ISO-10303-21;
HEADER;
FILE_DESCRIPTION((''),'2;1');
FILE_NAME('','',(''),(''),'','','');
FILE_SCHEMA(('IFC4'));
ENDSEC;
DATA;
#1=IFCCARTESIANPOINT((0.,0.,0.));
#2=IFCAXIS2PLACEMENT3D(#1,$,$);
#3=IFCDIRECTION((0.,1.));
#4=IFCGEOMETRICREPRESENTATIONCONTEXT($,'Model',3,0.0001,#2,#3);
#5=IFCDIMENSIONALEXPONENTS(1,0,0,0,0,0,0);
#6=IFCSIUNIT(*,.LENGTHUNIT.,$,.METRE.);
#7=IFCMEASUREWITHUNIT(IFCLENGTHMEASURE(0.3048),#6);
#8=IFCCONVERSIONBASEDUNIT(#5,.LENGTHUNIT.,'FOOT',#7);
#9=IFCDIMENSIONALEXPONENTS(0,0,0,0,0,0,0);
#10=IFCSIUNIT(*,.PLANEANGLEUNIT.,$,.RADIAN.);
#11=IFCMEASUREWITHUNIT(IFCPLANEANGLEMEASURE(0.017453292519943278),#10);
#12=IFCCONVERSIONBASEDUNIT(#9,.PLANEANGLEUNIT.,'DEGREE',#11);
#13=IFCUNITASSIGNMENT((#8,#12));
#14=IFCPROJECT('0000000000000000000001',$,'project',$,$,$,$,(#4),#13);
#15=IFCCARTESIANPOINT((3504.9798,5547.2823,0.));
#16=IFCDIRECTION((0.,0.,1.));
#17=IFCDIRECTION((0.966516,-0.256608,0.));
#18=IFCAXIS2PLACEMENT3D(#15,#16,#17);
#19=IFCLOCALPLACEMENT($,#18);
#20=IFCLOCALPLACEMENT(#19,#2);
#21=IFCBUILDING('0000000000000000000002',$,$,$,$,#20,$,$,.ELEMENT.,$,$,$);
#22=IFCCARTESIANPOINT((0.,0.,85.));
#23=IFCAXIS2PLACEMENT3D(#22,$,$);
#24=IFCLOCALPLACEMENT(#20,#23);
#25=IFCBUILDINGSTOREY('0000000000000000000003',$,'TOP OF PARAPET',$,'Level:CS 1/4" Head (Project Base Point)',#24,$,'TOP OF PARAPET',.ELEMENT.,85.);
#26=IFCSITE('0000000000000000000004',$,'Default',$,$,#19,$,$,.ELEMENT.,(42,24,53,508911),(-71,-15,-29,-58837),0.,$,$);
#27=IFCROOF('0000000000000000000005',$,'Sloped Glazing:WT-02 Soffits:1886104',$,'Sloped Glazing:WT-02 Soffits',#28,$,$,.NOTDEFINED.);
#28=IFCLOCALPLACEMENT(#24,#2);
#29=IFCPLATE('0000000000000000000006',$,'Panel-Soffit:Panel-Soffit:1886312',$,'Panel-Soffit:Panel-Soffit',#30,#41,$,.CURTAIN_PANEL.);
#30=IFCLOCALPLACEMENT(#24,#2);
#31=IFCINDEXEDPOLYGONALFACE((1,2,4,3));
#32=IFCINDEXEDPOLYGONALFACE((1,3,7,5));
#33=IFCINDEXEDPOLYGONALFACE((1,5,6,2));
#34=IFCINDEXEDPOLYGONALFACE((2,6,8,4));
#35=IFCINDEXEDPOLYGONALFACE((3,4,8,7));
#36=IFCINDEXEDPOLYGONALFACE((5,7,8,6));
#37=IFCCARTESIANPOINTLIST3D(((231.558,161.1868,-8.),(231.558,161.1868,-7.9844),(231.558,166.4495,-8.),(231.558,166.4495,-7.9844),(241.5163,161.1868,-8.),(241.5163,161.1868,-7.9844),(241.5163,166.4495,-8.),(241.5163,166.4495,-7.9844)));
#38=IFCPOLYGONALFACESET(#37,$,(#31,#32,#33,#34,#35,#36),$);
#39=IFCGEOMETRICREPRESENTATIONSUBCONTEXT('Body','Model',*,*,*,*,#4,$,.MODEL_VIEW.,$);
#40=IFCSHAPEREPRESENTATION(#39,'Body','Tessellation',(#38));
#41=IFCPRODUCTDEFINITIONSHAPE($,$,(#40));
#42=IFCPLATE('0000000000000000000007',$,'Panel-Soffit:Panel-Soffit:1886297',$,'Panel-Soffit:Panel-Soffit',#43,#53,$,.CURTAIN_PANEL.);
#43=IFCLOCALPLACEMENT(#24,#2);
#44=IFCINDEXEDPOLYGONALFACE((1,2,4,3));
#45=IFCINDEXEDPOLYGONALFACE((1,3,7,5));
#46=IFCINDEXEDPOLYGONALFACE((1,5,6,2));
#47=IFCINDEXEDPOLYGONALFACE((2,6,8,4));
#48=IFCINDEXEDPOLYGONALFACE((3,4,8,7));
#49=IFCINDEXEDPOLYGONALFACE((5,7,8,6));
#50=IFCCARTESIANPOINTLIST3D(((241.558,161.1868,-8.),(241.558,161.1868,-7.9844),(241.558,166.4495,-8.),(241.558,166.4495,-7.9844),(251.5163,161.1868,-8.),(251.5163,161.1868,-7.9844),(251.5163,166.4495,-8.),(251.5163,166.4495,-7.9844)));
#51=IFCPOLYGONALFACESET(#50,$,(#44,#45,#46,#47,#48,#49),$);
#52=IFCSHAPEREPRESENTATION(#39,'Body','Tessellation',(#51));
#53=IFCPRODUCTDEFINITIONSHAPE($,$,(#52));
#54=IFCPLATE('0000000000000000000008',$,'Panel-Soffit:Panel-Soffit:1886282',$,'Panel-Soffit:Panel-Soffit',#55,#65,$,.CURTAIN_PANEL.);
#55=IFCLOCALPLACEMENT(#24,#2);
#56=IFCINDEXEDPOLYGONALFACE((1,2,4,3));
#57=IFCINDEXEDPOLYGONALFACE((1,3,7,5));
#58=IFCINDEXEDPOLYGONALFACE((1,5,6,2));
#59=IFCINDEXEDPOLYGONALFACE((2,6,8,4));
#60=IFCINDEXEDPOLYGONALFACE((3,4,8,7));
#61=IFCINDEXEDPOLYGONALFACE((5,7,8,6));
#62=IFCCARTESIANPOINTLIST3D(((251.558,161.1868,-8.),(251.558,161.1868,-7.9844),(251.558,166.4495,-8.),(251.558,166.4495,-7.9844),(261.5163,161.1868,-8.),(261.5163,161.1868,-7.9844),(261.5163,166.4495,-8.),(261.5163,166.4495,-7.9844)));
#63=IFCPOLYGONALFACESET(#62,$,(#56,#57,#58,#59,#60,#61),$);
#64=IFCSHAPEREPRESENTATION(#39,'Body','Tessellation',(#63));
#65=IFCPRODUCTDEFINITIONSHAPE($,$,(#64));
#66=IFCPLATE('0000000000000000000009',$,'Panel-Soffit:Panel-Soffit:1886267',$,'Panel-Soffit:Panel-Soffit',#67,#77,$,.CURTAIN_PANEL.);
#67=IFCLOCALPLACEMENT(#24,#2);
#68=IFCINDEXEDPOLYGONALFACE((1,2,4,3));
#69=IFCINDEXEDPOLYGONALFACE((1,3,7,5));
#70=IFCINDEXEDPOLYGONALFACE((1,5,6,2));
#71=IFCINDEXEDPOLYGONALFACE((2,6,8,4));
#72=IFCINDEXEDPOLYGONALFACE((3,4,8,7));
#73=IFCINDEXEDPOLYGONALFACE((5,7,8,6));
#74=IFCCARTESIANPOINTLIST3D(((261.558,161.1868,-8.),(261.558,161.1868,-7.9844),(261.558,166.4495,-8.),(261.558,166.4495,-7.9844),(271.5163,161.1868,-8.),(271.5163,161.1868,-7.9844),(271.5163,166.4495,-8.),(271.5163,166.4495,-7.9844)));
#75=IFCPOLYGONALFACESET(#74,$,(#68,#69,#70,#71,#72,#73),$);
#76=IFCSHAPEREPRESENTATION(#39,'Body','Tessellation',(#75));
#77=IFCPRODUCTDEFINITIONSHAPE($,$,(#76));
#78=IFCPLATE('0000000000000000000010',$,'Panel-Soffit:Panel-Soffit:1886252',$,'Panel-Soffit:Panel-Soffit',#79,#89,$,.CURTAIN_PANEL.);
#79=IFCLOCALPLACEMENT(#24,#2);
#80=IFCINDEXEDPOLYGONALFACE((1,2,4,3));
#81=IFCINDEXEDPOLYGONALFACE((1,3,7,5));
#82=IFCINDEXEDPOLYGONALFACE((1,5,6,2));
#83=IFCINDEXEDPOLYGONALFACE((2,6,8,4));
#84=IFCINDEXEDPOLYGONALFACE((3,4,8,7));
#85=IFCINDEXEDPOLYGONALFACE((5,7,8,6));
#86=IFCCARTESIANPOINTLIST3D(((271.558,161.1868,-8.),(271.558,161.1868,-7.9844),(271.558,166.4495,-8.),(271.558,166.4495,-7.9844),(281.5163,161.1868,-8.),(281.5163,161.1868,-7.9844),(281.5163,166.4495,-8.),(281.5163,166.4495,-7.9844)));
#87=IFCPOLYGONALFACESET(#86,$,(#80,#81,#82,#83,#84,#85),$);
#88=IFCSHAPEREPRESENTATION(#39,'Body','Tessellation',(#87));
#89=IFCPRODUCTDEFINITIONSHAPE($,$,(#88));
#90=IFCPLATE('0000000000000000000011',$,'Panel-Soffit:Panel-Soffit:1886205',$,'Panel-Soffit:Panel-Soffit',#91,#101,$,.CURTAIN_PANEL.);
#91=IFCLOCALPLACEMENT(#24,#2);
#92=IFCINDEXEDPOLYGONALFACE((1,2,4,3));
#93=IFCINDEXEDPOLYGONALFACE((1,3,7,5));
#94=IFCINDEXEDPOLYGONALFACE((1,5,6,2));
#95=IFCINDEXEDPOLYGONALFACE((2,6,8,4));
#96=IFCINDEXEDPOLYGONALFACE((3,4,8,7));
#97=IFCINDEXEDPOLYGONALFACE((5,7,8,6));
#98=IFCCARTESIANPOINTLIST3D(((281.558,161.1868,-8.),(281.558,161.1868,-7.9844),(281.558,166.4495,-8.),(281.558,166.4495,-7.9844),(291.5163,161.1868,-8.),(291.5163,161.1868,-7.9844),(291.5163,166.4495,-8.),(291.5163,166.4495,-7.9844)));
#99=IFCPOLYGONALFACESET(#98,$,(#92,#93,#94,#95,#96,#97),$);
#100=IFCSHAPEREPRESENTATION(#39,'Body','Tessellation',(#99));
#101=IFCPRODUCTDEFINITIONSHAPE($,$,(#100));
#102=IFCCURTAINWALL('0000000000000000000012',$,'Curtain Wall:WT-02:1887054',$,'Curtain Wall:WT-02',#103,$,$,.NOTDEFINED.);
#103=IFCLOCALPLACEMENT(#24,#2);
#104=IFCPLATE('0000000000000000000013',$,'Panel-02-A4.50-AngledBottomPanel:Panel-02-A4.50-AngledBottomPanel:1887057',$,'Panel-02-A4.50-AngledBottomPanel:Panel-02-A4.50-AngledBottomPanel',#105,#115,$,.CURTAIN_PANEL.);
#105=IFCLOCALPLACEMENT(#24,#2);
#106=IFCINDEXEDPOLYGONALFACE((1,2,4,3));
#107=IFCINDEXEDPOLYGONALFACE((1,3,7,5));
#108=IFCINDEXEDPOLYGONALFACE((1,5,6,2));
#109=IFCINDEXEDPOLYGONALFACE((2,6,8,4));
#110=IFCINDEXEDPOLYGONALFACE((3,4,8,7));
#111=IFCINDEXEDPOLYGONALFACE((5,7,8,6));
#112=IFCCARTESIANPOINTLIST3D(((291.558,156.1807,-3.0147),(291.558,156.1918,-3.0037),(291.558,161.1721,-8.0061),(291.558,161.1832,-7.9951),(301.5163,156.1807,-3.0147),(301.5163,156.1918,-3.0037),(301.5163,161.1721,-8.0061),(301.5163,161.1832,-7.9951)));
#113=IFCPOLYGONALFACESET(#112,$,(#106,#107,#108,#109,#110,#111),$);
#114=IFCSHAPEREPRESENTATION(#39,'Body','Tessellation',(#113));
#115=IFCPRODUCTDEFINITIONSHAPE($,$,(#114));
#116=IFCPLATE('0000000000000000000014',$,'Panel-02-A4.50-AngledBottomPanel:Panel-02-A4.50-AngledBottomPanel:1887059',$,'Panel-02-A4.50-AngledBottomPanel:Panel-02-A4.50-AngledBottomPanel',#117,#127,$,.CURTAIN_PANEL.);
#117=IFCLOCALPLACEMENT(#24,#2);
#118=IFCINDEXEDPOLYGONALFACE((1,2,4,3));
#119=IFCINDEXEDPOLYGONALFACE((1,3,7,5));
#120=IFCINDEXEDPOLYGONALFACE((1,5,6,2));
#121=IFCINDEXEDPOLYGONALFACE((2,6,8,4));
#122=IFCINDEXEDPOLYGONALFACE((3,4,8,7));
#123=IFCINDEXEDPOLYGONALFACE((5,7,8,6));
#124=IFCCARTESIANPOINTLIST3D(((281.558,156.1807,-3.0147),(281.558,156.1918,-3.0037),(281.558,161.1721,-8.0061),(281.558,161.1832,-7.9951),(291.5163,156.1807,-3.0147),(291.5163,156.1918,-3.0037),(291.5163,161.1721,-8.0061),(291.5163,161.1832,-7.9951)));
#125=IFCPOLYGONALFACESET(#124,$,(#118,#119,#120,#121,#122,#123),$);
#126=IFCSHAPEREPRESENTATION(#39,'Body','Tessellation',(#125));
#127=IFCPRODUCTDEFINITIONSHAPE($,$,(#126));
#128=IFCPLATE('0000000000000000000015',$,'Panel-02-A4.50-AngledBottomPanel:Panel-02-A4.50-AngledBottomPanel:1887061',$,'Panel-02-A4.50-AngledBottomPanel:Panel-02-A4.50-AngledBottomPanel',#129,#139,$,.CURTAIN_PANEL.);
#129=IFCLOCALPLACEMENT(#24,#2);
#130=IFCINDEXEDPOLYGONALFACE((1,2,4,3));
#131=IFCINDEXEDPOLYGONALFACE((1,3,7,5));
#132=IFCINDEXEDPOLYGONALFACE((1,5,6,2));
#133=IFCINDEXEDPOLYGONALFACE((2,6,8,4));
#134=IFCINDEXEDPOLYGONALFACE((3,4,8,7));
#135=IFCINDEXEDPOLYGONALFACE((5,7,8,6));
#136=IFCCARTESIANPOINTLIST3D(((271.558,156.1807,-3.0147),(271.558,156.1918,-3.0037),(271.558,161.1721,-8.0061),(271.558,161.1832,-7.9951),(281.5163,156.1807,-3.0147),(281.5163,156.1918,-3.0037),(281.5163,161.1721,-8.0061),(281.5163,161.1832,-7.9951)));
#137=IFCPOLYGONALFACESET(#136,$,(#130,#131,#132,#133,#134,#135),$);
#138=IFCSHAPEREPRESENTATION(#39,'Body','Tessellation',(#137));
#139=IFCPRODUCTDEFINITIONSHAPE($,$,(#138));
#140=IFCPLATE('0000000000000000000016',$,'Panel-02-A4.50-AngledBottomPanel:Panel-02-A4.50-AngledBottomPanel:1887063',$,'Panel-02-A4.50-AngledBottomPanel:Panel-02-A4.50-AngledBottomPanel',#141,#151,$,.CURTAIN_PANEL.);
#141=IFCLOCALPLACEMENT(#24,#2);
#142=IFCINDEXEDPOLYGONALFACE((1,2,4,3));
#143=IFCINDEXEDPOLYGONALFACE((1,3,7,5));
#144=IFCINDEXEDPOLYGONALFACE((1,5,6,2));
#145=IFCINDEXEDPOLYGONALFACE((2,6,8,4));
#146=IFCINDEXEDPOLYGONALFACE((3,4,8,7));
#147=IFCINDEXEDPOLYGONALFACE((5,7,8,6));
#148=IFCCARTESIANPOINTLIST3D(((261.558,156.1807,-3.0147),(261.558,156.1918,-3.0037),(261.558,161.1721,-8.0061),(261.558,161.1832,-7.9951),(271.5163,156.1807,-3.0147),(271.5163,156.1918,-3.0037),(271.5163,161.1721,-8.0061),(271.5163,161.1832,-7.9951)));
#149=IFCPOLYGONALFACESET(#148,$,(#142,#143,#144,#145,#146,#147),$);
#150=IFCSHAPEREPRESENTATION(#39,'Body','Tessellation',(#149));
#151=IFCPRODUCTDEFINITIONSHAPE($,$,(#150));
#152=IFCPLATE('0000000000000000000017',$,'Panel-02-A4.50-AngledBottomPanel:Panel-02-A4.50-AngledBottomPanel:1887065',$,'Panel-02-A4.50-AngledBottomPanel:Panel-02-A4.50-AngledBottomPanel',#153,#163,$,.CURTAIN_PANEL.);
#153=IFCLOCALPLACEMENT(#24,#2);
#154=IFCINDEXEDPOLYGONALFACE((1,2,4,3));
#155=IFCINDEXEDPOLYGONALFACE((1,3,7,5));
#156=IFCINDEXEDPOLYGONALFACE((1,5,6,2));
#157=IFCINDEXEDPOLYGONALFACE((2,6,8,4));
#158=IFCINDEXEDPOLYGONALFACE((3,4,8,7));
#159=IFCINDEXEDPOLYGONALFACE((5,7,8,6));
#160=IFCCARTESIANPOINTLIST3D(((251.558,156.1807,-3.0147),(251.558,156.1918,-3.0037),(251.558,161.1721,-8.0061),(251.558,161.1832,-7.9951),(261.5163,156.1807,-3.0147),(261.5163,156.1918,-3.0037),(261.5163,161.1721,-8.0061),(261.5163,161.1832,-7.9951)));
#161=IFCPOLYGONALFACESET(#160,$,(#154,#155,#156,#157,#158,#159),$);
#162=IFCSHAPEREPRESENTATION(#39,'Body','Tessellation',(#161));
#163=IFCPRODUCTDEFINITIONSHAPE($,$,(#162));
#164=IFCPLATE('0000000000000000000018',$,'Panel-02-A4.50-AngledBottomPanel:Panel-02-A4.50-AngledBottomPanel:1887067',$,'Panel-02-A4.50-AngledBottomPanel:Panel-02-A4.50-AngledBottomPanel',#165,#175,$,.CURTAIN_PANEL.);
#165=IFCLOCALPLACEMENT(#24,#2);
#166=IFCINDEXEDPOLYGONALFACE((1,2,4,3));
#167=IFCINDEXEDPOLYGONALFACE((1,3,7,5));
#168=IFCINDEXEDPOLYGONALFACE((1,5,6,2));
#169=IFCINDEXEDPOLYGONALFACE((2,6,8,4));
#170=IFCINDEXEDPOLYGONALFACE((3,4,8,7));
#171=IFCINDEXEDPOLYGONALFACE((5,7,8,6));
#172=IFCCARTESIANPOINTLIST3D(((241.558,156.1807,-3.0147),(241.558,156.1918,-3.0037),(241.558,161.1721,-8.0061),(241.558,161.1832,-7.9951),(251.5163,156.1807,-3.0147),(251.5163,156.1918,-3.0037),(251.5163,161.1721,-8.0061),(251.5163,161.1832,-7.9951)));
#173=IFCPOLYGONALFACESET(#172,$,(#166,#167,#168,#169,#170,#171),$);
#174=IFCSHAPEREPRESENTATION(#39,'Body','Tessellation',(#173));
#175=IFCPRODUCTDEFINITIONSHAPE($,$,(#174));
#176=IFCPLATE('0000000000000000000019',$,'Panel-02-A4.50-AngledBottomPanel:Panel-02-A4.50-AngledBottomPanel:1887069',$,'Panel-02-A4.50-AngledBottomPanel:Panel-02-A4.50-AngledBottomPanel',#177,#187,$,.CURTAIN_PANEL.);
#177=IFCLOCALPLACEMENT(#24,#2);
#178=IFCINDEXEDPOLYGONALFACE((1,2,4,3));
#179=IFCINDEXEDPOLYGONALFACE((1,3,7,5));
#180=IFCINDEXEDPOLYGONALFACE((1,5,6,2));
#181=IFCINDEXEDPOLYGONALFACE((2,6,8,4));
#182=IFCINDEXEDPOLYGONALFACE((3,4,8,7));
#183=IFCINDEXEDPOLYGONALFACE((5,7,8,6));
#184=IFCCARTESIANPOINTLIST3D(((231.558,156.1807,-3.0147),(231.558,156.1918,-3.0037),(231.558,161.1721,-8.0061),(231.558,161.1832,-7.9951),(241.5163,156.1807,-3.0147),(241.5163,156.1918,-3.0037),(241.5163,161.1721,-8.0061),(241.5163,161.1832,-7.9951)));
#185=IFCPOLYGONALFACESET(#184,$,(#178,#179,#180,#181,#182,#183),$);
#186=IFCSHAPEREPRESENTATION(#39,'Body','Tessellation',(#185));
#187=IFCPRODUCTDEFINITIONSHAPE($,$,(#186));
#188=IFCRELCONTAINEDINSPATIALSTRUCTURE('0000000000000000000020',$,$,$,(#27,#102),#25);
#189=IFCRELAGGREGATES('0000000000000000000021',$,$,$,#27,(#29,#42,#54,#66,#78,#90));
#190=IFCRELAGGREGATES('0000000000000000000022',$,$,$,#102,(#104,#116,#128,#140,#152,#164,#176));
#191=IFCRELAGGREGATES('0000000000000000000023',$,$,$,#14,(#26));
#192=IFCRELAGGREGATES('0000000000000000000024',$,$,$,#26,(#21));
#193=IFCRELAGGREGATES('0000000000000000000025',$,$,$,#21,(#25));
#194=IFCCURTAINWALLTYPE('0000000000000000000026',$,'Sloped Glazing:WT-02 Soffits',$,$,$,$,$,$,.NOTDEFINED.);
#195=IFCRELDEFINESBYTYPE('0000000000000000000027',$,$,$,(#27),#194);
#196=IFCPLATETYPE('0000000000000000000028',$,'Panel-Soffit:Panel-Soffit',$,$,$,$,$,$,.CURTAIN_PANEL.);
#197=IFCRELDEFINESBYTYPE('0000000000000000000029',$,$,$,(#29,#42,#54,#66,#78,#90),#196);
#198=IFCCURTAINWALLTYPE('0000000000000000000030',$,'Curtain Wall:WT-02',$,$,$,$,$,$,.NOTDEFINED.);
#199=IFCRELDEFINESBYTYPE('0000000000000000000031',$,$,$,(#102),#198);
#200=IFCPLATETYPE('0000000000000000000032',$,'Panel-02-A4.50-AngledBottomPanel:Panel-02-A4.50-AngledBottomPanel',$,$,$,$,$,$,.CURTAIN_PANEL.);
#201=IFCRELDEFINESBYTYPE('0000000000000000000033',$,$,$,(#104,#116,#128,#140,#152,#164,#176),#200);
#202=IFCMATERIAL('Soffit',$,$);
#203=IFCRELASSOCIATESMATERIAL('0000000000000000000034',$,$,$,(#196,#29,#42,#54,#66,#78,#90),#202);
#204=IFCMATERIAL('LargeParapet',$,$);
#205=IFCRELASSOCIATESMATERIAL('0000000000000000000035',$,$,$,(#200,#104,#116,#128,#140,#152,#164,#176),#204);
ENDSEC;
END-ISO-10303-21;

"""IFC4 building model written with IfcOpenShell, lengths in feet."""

from ifc_helpers import new_model, entity, si_unit, converted_unit, direction, frame, origin, place, context, subcontext, project, spatial, indexed_curve, outline, extrude, source, transform, mapped, material, type_object, type_shapes, element, aggregate, save


model = new_model("IFC4")

# Units and contexts
model_context = context("Model", 3, precision=0.0001, world=origin(), true_north=direction((0.0, 1.0)))
body_context = subcontext(model_context, "Body", "Model", "MODEL_VIEW")
ifc_project = project(units=[converted_unit("LENGTHUNIT", "FOOT", entity("IfcLengthMeasure", 0.3048), si_unit("LENGTHUNIT", "METRE"), dimensions=[1, 0, 0, 0, 0, 0, 0]), converted_unit("PLANEANGLEUNIT", "DEGREE", entity("IfcPlaneAngleMeasure", 0.017453292519943278), si_unit("PLANEANGLEUNIT", "RADIAN"), dimensions=[0, 0, 0, 0, 0, 0, 0])], contexts=[model_context])

# Site, building, storey
site_placement = place(None, frame((3504.9798, 5547.2823, 0.0), z_axis=(0.0, 0.0, 1.0), x_axis=(0.966516, -0.256608, 0.0)))
site = spatial("IfcSite", under=ifc_project, at=site_placement, Name="Default", CompositionType="ELEMENT", RefLatitude=(42, 24, 53, 508911), RefLongitude=(-71, -15, -29, -58837), RefElevation=0.0)
building_placement = place(site_placement, origin())
building = spatial("IfcBuilding", under=site, at=building_placement, CompositionType="ELEMENT")
storey_placement = place(building_placement, frame((0.0, 0.0, 85.0)))
storey = spatial("IfcBuildingStorey", under=building, at=storey_placement, Name="TOP OF PARAPET", ObjectType="Level:CS 1/4\" Head (Project Base Point)", LongName="TOP OF PARAPET", CompositionType="ELEMENT", Elevation=85.0)

# Shared definitions
curtain_wall_type_1 = type_object("IfcCurtainWallType", Name="Curtain Wall:WT-02", PredefinedType="NOTDEFINED")
ifc_material_1 = material(Name="LargeParapet")

# Roof, plates
curtain_wall_type_2 = type_object("IfcCurtainWallType", Name="Sloped Glazing:WT-02 Soffits", PredefinedType="NOTDEFINED")
roof_placement = place(storey_placement, frame((0.0, 0.0, -85.0)))
roof = element("IfcRoof", 1, at=roof_placement, inside=storey, type_object=curtain_wall_type_2, Name="Sloped Glazing:WT-02 Soffits:1886104", ObjectType="Sloped Glazing:WT-02 Soffits", PredefinedType="NOTDEFINED")
ifc_material_2 = material(Name="Soffit")
plate_type_1 = type_object("IfcPlateType", Name="Panel-Soffit:Panel-Soffit", PredefinedType="CURTAIN_PANEL", material=ifc_material_2)
shared_shape_1 = source(origin(), body_context, "Body", "SweptSolid", [
    extrude(outline(indexed_curve([(-0.0078, -4.9792), (0.0078, -4.9792), (0.0078, 4.9792), (-0.0078, 4.9792), (-0.0078, -4.9792)], self_intersect=False)), frame((4.9792, 0.0078, 0.0), z_axis=(0.0, 0.0, 1.0), x_axis=(0.0, -1.0, 0.0)), (0.0, 0.0, 1.0), 5.2626),
])
type_shapes(plate_type_1, [shared_shape_1])
plate_1_placement = place(roof_placement, frame((231.558, 161.1868, 77.0156), z_axis=(0.0, 1.0, 0.0), x_axis=(1.0, 0.0, 0.0)))
plate_1 = element("IfcPlate", 2, at=plate_1_placement, type_object=plate_type_1, material=ifc_material_2, Name="Panel-Soffit:Panel-Soffit:1886312", ObjectType="Panel-Soffit:Panel-Soffit", PredefinedType="CURTAIN_PANEL", context=body_context, shape_type="MappedRepresentation", body=[
    mapped(shared_shape_1, transform((0.0, 0.0, 0.0), scale=1.0)),
])
plate_2_placement = place(roof_placement, frame((241.558, 161.1868, 77.0156), z_axis=(0.0, 1.0, 0.0), x_axis=(1.0, 0.0, 0.0)))
plate_2 = element("IfcPlate", 3, at=plate_2_placement, type_object=plate_type_1, material=ifc_material_2, Name="Panel-Soffit:Panel-Soffit:1886297", ObjectType="Panel-Soffit:Panel-Soffit", PredefinedType="CURTAIN_PANEL", context=body_context, shape_type="MappedRepresentation", body=[
    mapped(shared_shape_1, transform((0.0, 0.0, 0.0), scale=1.0)),
])
plate_3_placement = place(roof_placement, frame((251.558, 161.1868, 77.0156), z_axis=(0.0, 1.0, 0.0), x_axis=(1.0, 0.0, 0.0)))
plate_3 = element("IfcPlate", 4, at=plate_3_placement, type_object=plate_type_1, material=ifc_material_2, Name="Panel-Soffit:Panel-Soffit:1886282", ObjectType="Panel-Soffit:Panel-Soffit", PredefinedType="CURTAIN_PANEL", context=body_context, shape_type="MappedRepresentation", body=[
    mapped(shared_shape_1, transform((0.0, 0.0, 0.0), scale=1.0)),
])
plate_4_placement = place(roof_placement, frame((261.558, 161.1868, 77.0156), z_axis=(0.0, 1.0, 0.0), x_axis=(1.0, 0.0, 0.0)))
plate_4 = element("IfcPlate", 5, at=plate_4_placement, type_object=plate_type_1, material=ifc_material_2, Name="Panel-Soffit:Panel-Soffit:1886267", ObjectType="Panel-Soffit:Panel-Soffit", PredefinedType="CURTAIN_PANEL", context=body_context, shape_type="MappedRepresentation", body=[
    mapped(shared_shape_1, transform((0.0, 0.0, 0.0), scale=1.0)),
])
plate_5_placement = place(roof_placement, frame((271.558, 161.1868, 77.0156), z_axis=(0.0, 1.0, 0.0), x_axis=(1.0, 0.0, 0.0)))
plate_5 = element("IfcPlate", 6, at=plate_5_placement, type_object=plate_type_1, material=ifc_material_2, Name="Panel-Soffit:Panel-Soffit:1886252", ObjectType="Panel-Soffit:Panel-Soffit", PredefinedType="CURTAIN_PANEL", context=body_context, shape_type="MappedRepresentation", body=[
    mapped(shared_shape_1, transform((0.0, 0.0, 0.0), scale=1.0)),
])
plate_6_placement = place(roof_placement, frame((281.558, 161.1868, 77.0156), z_axis=(0.0, 1.0, 0.0), x_axis=(1.0, 0.0, 0.0)))
plate_6 = element("IfcPlate", 7, at=plate_6_placement, type_object=plate_type_1, material=ifc_material_2, Name="Panel-Soffit:Panel-Soffit:1886205", ObjectType="Panel-Soffit:Panel-Soffit", PredefinedType="CURTAIN_PANEL", context=body_context, shape_type="MappedRepresentation", body=[
    mapped(shared_shape_1, transform((0.0, 0.0, 0.0), scale=1.0)),
])
aggregate(roof, [plate_1, plate_2, plate_3, plate_4, plate_5, plate_6])

# Curtain wall, plates
curtain_wall_1_placement = place(storey_placement, frame((0.0, 0.0, -85.0)))
curtain_wall_1 = element("IfcCurtainWall", 8, at=curtain_wall_1_placement, inside=storey, type_object=curtain_wall_type_1, Name="Curtain Wall:WT-02:1887054", ObjectType="Curtain Wall:WT-02", PredefinedType="NOTDEFINED")
plate_type_2 = type_object("IfcPlateType", Name="Panel-02-A4.50-AngledBottomPanel:Panel-02-A4.50-AngledBottomPanel", PredefinedType="CURTAIN_PANEL", material=ifc_material_1)
shared_shape_2 = source(origin(), body_context, "Body", "SweptSolid", [
    extrude(outline(indexed_curve([(-0.0078, -4.9792), (0.0078, -4.9792), (0.0078, 4.9792), (-0.0078, 4.9792), (-0.0078, -4.9792)], self_intersect=False)), frame((4.9792, 0.0078, 0.0), z_axis=(0.0, 0.0, 1.0), x_axis=(0.0, -1.0, 0.0)), (0.0, 0.0, 1.0), 7.0589),
])
type_shapes(plate_type_2, [shared_shape_2])
plate_7_placement = place(curtain_wall_1_placement, frame((301.5163, 161.1832, 77.0049), z_axis=(0.0, -0.707107, 0.707107), x_axis=(-1.0, 0.0, 0.0)))
plate_7 = element("IfcPlate", 9, at=plate_7_placement, type_object=plate_type_2, material=ifc_material_1, Name="Panel-02-A4.50-AngledBottomPanel:Panel-02-A4.50-AngledBottomPanel:1887057", ObjectType="Panel-02-A4.50-AngledBottomPanel:Panel-02-A4.50-AngledBottomPanel", PredefinedType="CURTAIN_PANEL", context=body_context, shape_type="MappedRepresentation", body=[
    mapped(shared_shape_2, transform((0.0, 0.0, 0.0), scale=1.0)),
])
plate_8_placement = place(curtain_wall_1_placement, frame((291.5163, 161.1832, 77.0049), z_axis=(0.0, -0.707107, 0.707107), x_axis=(-1.0, 0.0, 0.0)))
plate_8 = element("IfcPlate", 10, at=plate_8_placement, type_object=plate_type_2, material=ifc_material_1, Name="Panel-02-A4.50-AngledBottomPanel:Panel-02-A4.50-AngledBottomPanel:1887059", ObjectType="Panel-02-A4.50-AngledBottomPanel:Panel-02-A4.50-AngledBottomPanel", PredefinedType="CURTAIN_PANEL", context=body_context, shape_type="MappedRepresentation", body=[
    mapped(shared_shape_2, transform((0.0, 0.0, 0.0), scale=1.0)),
])
plate_9_placement = place(curtain_wall_1_placement, frame((281.5163, 161.1832, 77.0049), z_axis=(0.0, -0.707107, 0.707107), x_axis=(-1.0, 0.0, 0.0)))
plate_9 = element("IfcPlate", 11, at=plate_9_placement, type_object=plate_type_2, material=ifc_material_1, Name="Panel-02-A4.50-AngledBottomPanel:Panel-02-A4.50-AngledBottomPanel:1887061", ObjectType="Panel-02-A4.50-AngledBottomPanel:Panel-02-A4.50-AngledBottomPanel", PredefinedType="CURTAIN_PANEL", context=body_context, shape_type="MappedRepresentation", body=[
    mapped(shared_shape_2, transform((0.0, 0.0, 0.0), scale=1.0)),
])
plate_10_placement = place(curtain_wall_1_placement, frame((271.5163, 161.1832, 77.0049), z_axis=(0.0, -0.707107, 0.707107), x_axis=(-1.0, 0.0, 0.0)))
plate_10 = element("IfcPlate", 12, at=plate_10_placement, type_object=plate_type_2, material=ifc_material_1, Name="Panel-02-A4.50-AngledBottomPanel:Panel-02-A4.50-AngledBottomPanel:1887063", ObjectType="Panel-02-A4.50-AngledBottomPanel:Panel-02-A4.50-AngledBottomPanel", PredefinedType="CURTAIN_PANEL", context=body_context, shape_type="MappedRepresentation", body=[
    mapped(shared_shape_2, transform((0.0, 0.0, 0.0), scale=1.0)),
])
plate_11_placement = place(curtain_wall_1_placement, frame((261.5163, 161.1832, 77.0049), z_axis=(0.0, -0.707107, 0.707107), x_axis=(-1.0, 0.0, 0.0)))
plate_11 = element("IfcPlate", 13, at=plate_11_placement, type_object=plate_type_2, material=ifc_material_1, Name="Panel-02-A4.50-AngledBottomPanel:Panel-02-A4.50-AngledBottomPanel:1887065", ObjectType="Panel-02-A4.50-AngledBottomPanel:Panel-02-A4.50-AngledBottomPanel", PredefinedType="CURTAIN_PANEL", context=body_context, shape_type="MappedRepresentation", body=[
    mapped(shared_shape_2, transform((0.0, 0.0, 0.0), scale=1.0)),
])
plate_12_placement = place(curtain_wall_1_placement, frame((251.5163, 161.1832, 77.0049), z_axis=(0.0, -0.707107, 0.707107), x_axis=(-1.0, 0.0, 0.0)))
plate_12 = element("IfcPlate", 14, at=plate_12_placement, type_object=plate_type_2, material=ifc_material_1, Name="Panel-02-A4.50-AngledBottomPanel:Panel-02-A4.50-AngledBottomPanel:1887067", ObjectType="Panel-02-A4.50-AngledBottomPanel:Panel-02-A4.50-AngledBottomPanel", PredefinedType="CURTAIN_PANEL", context=body_context, shape_type="MappedRepresentation", body=[
    mapped(shared_shape_2, transform((0.0, 0.0, 0.0), scale=1.0)),
])
plate_13_placement = place(curtain_wall_1_placement, frame((241.5163, 161.1832, 77.0049), z_axis=(0.0, -0.707107, 0.707107), x_axis=(-1.0, 0.0, 0.0)))
plate_13 = element("IfcPlate", 15, at=plate_13_placement, type_object=plate_type_2, material=ifc_material_1, Name="Panel-02-A4.50-AngledBottomPanel:Panel-02-A4.50-AngledBottomPanel:1887069", ObjectType="Panel-02-A4.50-AngledBottomPanel:Panel-02-A4.50-AngledBottomPanel", PredefinedType="CURTAIN_PANEL", context=body_context, shape_type="MappedRepresentation", body=[
    mapped(shared_shape_2, transform((0.0, 0.0, 0.0), scale=1.0)),
])
aggregate(curtain_wall_1, [plate_7, plate_8, plate_9, plate_10, plate_11, plate_12, plate_13])

save(model, "model.ifc")
